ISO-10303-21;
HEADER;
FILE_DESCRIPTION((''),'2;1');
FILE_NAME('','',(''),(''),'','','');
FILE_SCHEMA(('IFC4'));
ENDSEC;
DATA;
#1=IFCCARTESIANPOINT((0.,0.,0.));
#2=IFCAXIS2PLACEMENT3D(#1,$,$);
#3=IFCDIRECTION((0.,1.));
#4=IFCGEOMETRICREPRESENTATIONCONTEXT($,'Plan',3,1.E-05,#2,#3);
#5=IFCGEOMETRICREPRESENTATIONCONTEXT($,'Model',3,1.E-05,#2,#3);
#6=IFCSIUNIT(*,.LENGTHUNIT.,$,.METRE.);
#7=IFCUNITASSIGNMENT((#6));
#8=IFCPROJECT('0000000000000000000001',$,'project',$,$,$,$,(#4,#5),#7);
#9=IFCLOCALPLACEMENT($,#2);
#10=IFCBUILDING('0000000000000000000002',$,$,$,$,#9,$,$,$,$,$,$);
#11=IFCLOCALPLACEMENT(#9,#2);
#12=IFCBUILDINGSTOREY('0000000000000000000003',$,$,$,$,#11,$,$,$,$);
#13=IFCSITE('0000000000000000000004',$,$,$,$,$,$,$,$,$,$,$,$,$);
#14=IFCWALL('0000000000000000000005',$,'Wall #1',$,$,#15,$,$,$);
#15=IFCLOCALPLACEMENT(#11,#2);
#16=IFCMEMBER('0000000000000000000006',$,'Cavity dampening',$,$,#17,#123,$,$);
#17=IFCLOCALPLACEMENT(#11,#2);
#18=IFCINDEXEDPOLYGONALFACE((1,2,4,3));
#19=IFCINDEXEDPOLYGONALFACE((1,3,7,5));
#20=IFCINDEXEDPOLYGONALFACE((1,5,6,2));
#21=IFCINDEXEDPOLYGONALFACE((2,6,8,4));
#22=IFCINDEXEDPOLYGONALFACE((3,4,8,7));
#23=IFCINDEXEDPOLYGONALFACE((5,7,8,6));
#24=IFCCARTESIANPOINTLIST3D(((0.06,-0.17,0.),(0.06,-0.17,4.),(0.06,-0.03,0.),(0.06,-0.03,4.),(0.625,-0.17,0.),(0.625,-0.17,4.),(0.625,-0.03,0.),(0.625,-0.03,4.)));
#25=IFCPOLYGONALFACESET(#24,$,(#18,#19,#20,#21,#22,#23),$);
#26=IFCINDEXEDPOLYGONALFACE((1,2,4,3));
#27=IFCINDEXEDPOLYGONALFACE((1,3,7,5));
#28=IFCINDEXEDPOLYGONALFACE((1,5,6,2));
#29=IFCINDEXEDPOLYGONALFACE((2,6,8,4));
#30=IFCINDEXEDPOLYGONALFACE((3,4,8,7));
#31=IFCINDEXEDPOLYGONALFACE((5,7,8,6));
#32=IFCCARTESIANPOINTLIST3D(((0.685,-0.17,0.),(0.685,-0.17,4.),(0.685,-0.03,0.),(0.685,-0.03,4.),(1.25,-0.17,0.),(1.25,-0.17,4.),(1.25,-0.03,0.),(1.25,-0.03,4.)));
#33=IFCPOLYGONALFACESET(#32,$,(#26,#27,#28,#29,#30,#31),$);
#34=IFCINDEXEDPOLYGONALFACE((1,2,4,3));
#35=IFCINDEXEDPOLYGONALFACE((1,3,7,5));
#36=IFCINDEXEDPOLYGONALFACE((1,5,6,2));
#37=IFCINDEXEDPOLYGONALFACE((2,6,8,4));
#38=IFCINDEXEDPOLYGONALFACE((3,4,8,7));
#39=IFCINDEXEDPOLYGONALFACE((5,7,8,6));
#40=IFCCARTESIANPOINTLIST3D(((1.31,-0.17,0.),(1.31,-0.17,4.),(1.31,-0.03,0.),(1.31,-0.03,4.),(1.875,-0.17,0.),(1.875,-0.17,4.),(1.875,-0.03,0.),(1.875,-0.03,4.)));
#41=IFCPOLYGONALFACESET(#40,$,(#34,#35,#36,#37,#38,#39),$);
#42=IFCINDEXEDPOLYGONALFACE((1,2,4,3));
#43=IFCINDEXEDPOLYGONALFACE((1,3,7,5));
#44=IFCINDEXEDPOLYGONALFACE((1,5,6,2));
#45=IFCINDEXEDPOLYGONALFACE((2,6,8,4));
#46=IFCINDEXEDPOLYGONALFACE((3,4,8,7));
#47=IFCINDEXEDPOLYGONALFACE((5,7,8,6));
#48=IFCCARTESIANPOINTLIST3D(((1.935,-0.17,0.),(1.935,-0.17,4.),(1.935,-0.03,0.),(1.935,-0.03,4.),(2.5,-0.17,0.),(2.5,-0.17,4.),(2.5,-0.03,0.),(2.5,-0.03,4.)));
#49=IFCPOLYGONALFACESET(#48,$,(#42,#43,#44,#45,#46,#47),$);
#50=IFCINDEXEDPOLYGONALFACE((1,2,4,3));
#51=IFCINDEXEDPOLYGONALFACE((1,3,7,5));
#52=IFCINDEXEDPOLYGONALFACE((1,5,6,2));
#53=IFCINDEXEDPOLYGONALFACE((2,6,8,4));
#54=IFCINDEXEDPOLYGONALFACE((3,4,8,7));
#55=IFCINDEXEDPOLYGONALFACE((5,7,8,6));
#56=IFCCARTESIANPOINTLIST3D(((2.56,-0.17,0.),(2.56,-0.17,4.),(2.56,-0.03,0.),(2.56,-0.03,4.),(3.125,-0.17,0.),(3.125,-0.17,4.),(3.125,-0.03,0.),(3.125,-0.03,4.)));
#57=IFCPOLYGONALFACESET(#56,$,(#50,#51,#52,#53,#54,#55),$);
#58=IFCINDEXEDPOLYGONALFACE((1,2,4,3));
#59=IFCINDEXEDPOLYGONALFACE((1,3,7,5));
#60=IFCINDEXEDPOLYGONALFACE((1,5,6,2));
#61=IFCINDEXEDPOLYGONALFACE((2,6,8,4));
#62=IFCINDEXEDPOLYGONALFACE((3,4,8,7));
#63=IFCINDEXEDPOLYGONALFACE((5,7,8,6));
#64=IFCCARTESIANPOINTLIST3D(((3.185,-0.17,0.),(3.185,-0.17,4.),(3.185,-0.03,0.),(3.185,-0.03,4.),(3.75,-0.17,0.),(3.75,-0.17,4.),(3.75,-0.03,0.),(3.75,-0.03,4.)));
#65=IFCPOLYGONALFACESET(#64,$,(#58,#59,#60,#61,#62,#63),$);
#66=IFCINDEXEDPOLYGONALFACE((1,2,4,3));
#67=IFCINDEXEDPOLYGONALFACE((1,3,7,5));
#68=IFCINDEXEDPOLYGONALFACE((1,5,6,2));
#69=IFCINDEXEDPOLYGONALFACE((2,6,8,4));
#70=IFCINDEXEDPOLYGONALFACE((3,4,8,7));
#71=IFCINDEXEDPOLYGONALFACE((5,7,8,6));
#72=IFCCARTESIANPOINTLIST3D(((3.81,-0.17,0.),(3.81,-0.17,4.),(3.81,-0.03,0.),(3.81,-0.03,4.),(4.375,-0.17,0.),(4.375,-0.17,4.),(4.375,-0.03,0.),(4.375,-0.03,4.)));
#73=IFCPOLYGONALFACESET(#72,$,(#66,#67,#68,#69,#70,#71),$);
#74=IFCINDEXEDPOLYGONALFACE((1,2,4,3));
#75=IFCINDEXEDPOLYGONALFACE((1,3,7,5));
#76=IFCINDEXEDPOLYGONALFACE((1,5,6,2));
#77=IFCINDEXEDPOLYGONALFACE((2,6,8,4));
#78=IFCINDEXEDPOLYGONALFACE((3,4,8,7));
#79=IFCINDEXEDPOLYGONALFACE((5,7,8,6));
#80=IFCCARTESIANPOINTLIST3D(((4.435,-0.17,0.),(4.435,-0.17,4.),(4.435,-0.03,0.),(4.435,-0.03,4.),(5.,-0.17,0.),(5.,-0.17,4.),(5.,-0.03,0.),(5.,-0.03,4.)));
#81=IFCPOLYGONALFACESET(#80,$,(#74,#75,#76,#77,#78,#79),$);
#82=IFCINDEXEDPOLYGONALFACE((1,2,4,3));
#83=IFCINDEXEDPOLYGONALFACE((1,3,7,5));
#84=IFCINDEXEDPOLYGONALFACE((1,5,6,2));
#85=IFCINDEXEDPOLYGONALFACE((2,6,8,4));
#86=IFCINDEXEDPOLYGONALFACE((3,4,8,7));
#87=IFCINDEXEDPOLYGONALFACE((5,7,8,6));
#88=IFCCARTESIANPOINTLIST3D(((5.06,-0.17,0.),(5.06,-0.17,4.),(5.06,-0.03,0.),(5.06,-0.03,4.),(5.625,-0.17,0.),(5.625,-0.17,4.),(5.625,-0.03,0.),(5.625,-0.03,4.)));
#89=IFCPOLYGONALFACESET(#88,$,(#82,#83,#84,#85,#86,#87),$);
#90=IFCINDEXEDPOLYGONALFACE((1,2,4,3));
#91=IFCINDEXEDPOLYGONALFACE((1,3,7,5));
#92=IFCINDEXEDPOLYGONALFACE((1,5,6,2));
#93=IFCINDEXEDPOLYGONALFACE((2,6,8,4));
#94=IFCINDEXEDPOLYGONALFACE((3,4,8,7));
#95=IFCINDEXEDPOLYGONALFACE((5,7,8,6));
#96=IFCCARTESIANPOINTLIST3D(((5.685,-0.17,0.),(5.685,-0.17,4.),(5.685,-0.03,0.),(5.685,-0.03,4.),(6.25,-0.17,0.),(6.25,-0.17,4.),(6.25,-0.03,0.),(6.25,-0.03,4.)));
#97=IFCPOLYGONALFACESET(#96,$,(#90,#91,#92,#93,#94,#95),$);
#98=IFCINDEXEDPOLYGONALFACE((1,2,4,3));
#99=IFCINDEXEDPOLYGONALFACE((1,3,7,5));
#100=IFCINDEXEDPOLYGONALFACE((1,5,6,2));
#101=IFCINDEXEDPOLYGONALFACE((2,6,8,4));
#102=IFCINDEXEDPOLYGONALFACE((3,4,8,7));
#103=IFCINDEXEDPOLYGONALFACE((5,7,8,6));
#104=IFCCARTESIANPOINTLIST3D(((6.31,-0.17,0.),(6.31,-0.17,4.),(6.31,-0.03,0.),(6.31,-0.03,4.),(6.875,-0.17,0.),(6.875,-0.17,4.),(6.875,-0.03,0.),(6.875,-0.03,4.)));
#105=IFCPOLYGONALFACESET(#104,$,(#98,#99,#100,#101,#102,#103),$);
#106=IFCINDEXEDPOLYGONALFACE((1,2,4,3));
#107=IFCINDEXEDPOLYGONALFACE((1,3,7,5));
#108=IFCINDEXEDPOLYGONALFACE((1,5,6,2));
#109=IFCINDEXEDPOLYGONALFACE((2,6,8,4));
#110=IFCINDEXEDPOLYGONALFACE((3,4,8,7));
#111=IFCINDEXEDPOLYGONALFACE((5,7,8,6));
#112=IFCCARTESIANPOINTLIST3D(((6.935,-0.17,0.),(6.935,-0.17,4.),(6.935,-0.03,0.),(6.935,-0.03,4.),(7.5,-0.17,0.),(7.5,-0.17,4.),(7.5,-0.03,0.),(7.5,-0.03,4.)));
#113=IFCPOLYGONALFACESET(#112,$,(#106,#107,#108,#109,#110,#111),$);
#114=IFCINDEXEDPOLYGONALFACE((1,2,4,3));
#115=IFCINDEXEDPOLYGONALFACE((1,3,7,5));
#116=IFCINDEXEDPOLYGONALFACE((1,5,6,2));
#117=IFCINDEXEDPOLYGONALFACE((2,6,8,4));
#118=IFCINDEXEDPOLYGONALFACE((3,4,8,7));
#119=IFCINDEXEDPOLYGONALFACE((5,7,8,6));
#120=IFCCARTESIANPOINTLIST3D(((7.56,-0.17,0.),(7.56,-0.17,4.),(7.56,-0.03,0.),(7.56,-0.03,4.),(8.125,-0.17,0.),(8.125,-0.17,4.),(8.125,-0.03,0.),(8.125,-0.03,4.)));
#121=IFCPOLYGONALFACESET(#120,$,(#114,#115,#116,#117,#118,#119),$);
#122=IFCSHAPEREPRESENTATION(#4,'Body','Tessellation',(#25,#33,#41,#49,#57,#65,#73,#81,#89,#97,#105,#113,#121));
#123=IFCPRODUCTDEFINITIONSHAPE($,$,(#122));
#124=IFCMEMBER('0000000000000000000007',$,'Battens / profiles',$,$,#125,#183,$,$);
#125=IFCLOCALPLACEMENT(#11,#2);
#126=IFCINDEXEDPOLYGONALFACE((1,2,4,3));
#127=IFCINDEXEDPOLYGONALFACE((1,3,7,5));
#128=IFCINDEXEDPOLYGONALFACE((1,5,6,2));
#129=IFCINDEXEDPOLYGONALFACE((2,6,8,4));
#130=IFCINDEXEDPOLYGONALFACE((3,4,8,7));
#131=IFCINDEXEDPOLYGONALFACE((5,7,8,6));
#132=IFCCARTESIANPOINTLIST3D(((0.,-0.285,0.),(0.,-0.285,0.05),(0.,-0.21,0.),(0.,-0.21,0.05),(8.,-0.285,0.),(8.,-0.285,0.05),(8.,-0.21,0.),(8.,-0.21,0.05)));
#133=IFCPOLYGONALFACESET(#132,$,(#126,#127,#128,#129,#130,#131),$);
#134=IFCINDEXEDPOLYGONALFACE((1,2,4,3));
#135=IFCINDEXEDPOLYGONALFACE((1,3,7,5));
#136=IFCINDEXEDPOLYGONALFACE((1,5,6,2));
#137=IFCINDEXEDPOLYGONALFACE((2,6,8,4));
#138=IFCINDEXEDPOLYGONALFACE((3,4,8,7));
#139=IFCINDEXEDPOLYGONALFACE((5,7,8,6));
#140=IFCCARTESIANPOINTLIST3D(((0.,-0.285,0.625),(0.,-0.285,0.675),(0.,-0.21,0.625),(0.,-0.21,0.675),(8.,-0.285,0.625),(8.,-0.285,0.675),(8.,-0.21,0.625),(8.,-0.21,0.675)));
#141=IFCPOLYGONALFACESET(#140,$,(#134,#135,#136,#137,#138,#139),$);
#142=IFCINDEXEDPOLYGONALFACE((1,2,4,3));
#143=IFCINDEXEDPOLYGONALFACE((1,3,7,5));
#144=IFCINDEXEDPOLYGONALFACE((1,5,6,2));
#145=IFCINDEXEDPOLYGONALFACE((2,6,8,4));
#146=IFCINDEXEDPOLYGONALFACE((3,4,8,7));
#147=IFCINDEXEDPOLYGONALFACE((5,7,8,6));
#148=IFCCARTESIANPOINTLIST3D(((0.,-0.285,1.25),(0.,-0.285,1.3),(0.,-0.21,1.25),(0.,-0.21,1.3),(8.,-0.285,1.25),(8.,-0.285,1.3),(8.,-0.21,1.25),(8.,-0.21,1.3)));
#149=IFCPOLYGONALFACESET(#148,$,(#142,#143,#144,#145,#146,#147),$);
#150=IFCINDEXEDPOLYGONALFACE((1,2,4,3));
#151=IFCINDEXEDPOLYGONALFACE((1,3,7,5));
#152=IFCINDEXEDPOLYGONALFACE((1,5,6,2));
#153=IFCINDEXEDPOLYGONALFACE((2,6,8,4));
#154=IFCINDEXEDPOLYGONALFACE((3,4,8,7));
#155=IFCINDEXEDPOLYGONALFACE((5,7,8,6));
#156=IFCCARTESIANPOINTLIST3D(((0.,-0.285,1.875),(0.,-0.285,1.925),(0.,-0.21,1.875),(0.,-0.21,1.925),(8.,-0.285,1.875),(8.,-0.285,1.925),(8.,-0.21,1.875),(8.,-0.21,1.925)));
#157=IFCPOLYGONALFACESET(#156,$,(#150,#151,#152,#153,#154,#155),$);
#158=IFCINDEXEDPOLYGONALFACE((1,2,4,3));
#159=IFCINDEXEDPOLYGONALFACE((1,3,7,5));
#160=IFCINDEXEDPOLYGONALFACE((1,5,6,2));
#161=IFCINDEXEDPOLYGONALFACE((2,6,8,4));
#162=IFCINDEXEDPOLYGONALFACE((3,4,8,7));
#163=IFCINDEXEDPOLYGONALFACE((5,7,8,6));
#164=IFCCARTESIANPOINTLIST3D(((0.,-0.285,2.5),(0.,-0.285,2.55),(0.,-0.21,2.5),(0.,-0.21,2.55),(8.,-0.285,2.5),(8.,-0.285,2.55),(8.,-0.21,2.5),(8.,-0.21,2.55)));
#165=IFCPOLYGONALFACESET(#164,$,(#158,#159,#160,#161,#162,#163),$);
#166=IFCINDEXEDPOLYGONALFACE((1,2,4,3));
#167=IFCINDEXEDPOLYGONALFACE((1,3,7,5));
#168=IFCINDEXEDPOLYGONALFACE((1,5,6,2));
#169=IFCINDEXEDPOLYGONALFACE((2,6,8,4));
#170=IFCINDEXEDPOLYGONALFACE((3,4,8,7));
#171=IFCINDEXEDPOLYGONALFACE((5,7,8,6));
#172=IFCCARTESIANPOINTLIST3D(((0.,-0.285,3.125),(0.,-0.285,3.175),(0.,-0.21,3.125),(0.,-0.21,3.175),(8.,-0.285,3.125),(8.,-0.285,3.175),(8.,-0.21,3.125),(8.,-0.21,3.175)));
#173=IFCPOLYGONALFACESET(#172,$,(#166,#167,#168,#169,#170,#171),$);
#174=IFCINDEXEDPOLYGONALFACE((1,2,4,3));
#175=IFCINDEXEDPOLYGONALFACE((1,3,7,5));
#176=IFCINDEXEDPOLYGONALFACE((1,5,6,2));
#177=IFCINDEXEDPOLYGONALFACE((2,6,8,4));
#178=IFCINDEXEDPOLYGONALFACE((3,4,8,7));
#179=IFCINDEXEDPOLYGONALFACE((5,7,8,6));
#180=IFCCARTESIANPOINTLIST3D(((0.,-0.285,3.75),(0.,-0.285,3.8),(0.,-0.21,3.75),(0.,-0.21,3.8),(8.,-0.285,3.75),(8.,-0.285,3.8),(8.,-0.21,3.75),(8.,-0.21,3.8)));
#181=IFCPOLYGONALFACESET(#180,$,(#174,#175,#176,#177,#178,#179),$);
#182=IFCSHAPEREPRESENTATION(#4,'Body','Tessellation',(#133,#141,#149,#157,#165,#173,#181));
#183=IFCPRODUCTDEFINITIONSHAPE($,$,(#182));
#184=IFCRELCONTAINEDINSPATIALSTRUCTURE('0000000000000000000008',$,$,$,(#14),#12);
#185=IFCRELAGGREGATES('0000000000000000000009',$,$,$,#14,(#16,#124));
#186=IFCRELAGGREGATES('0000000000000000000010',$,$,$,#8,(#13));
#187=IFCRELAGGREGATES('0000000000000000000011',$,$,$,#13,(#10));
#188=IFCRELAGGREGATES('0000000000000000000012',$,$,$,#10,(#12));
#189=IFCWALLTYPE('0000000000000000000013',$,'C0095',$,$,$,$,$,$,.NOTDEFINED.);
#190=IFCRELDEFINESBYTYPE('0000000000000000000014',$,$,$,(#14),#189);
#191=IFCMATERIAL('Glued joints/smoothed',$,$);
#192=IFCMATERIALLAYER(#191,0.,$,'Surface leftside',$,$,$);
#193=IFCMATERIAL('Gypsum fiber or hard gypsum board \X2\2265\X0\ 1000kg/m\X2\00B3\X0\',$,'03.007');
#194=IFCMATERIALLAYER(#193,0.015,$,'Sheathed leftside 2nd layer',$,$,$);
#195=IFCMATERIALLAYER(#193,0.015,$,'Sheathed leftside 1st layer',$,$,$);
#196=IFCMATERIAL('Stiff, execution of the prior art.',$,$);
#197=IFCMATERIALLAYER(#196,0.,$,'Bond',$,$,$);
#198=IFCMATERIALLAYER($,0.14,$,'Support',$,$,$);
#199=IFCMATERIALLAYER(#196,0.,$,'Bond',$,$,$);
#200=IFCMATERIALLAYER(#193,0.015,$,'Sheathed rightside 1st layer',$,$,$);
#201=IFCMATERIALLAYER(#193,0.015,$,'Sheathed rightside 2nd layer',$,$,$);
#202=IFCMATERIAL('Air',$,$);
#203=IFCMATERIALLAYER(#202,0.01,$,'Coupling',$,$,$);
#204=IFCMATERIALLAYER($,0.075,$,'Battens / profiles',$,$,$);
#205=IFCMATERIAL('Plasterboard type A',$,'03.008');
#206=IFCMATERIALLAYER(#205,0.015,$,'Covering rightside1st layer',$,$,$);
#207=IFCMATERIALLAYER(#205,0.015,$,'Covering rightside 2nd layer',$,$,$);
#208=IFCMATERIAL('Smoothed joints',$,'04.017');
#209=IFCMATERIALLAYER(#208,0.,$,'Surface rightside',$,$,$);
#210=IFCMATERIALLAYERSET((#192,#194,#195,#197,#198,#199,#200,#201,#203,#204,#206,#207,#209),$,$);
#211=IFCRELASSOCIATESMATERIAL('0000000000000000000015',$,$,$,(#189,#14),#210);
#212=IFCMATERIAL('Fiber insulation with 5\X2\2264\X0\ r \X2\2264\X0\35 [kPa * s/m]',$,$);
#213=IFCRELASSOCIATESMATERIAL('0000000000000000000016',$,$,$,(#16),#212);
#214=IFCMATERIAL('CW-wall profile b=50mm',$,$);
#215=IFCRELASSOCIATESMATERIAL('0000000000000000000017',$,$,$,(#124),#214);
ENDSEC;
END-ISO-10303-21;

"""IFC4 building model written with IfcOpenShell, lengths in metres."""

from ifc_helpers import new_model, si_unit, direction, frame, frame_2d, origin, place, context, project, spatial, rectangle, extrude, material, layer, layer_set, type_object, element, aggregate, save


model = new_model("IFC4")

# Units and contexts
plan_context = context("Plan", 3, precision=1e-05, world=origin(), true_north=direction((0.0, 1.0)))
model_context = context("Model", 3, precision=1e-05, world=origin(), true_north=direction((0.0, 1.0)))
ifc_project = project(units=[si_unit("LENGTHUNIT", "METRE")], contexts=[plan_context, model_context])

# Site, building, storey
site = spatial("IfcSite", under=ifc_project)
building_placement = place(None, origin())
building = spatial("IfcBuilding", under=site, at=building_placement)
storey_placement = place(building_placement, origin())
storey = spatial("IfcBuildingStorey", under=building, at=storey_placement)

# Wall, members
ifc_material_1 = material(Name="Glued joints/smoothed")
ifc_layer_1 = layer(ifc_material_1, 0.0, Name="Surface leftside")
ifc_material_2 = material(Name="Gypsum fiber or hard gypsum board ≥ 1000kg/m³", Category="03.007")
ifc_layer_2 = layer(ifc_material_2, 0.015, Name="Sheathed leftside 2nd layer")
ifc_layer_3 = layer(ifc_material_2, 0.015, Name="Sheathed leftside 1st layer")
ifc_material_3 = material(Name="Stiff, execution of the prior art.")
ifc_layer_4 = layer(ifc_material_3, 0.0, Name="Bond")
ifc_layer_5 = layer(None, 0.14, Name="Support")
ifc_layer_6 = layer(ifc_material_3, 0.0, Name="Bond")
ifc_layer_7 = layer(ifc_material_2, 0.015, Name="Sheathed rightside 1st layer")
ifc_layer_8 = layer(ifc_material_2, 0.015, Name="Sheathed rightside 2nd layer")
ifc_material_4 = material(Name="Air")
ifc_layer_9 = layer(ifc_material_4, 0.01, Name="Coupling")
ifc_layer_10 = layer(None, 0.075, Name="Battens / profiles")
ifc_material_5 = material(Name="Plasterboard type A", Category="03.008")
ifc_layer_11 = layer(ifc_material_5, 0.015, Name="Covering rightside1st layer")
ifc_layer_12 = layer(ifc_material_5, 0.015, Name="Covering rightside 2nd layer")
ifc_material_6 = material(Name="Smoothed joints", Category="04.017")
ifc_layer_13 = layer(ifc_material_6, 0.0, Name="Surface rightside")
ifc_layer_set = layer_set([ifc_layer_1, ifc_layer_2, ifc_layer_3, ifc_layer_4, ifc_layer_5, ifc_layer_6, ifc_layer_7, ifc_layer_8, ifc_layer_9, ifc_layer_10, ifc_layer_11, ifc_layer_12, ifc_layer_13])
wall_type = type_object("IfcWallType", Name="C0095", PredefinedType="NOTDEFINED", material=ifc_layer_set)
wall_placement = place(None, frame((0.0, 0.0, 0.0), z_axis=(0.0, -1.0, 0.0), x_axis=(1.0, 0.0, 0.0)))
wall = element("IfcWall", 1, at=wall_placement, inside=storey, type_object=wall_type, material=ifc_layer_set, Name="Wall #1")
ifc_material_7 = material(Name="Fiber insulation with 5≤ r ≤35 [kPa * s/m]")
member_1_placement = place(wall_placement, origin())
member_1 = element("IfcMember", 2, at=member_1_placement, material=ifc_material_7, Name="Cavity dampening", context=plan_context, shape_type="SweptSolid", body=[
    extrude(rectangle(XDim=0.565, YDim=0.14, at=frame_2d((0.2825, 0.07), x_axis=(1.0, 0.0))), frame((0.06, 4.0, 0.03), z_axis=(0.0, -1.0, 0.0), x_axis=(1.0, 0.0, 0.0)), (0.0, 0.0, 1.0), 4.0),
    extrude(rectangle(XDim=0.565, YDim=0.14, at=frame_2d((0.2825, 0.07), x_axis=(1.0, 0.0))), frame((0.685, 4.0, 0.03), z_axis=(0.0, -1.0, 0.0), x_axis=(1.0, 0.0, 0.0)), (0.0, 0.0, 1.0), 4.0),
    extrude(rectangle(XDim=0.565, YDim=0.14, at=frame_2d((0.2825, 0.07), x_axis=(1.0, 0.0))), frame((1.31, 4.0, 0.03), z_axis=(0.0, -1.0, 0.0), x_axis=(1.0, 0.0, 0.0)), (0.0, 0.0, 1.0), 4.0),
    extrude(rectangle(XDim=0.565, YDim=0.14, at=frame_2d((0.2825, 0.07), x_axis=(1.0, 0.0))), frame((1.935, 4.0, 0.03), z_axis=(0.0, -1.0, 0.0), x_axis=(1.0, 0.0, 0.0)), (0.0, 0.0, 1.0), 4.0),
    extrude(rectangle(XDim=0.565, YDim=0.14, at=frame_2d((0.2825, 0.07), x_axis=(1.0, 0.0))), frame((2.56, 4.0, 0.03), z_axis=(0.0, -1.0, 0.0), x_axis=(1.0, 0.0, 0.0)), (0.0, 0.0, 1.0), 4.0),
    extrude(rectangle(XDim=0.565, YDim=0.14, at=frame_2d((0.2825, 0.07), x_axis=(1.0, 0.0))), frame((3.185, 4.0, 0.03), z_axis=(0.0, -1.0, 0.0), x_axis=(1.0, 0.0, 0.0)), (0.0, 0.0, 1.0), 4.0),
    extrude(rectangle(XDim=0.565, YDim=0.14, at=frame_2d((0.2825, 0.07), x_axis=(1.0, 0.0))), frame((3.81, 4.0, 0.03), z_axis=(0.0, -1.0, 0.0), x_axis=(1.0, 0.0, 0.0)), (0.0, 0.0, 1.0), 4.0),
    extrude(rectangle(XDim=0.565, YDim=0.14, at=frame_2d((0.2825, 0.07), x_axis=(1.0, 0.0))), frame((4.435, 4.0, 0.03), z_axis=(0.0, -1.0, 0.0), x_axis=(1.0, 0.0, 0.0)), (0.0, 0.0, 1.0), 4.0),
    extrude(rectangle(XDim=0.565, YDim=0.14, at=frame_2d((0.2825, 0.07), x_axis=(1.0, 0.0))), frame((5.06, 4.0, 0.03), z_axis=(0.0, -1.0, 0.0), x_axis=(1.0, 0.0, 0.0)), (0.0, 0.0, 1.0), 4.0),
    extrude(rectangle(XDim=0.565, YDim=0.14, at=frame_2d((0.2825, 0.07), x_axis=(1.0, 0.0))), frame((5.685, 4.0, 0.03), z_axis=(0.0, -1.0, 0.0), x_axis=(1.0, 0.0, 0.0)), (0.0, 0.0, 1.0), 4.0),
    extrude(rectangle(XDim=0.565, YDim=0.14, at=frame_2d((0.2825, 0.07), x_axis=(1.0, 0.0))), frame((6.31, 4.0, 0.03), z_axis=(0.0, -1.0, 0.0), x_axis=(1.0, 0.0, 0.0)), (0.0, 0.0, 1.0), 4.0),
    extrude(rectangle(XDim=0.565, YDim=0.14, at=frame_2d((0.2825, 0.07), x_axis=(1.0, 0.0))), frame((6.935, 4.0, 0.03), z_axis=(0.0, -1.0, 0.0), x_axis=(1.0, 0.0, 0.0)), (0.0, 0.0, 1.0), 4.0),
    extrude(rectangle(XDim=0.565, YDim=0.14, at=frame_2d((0.2825, 0.07), x_axis=(1.0, 0.0))), frame((7.56, 4.0, 0.03), z_axis=(0.0, -1.0, 0.0), x_axis=(1.0, 0.0, 0.0)), (0.0, 0.0, 1.0), 4.0),
])
ifc_material_8 = material(Name="CW-wall profile b=50mm")
member_2_placement = place(wall_placement, origin())
member_2 = element("IfcMember", 3, at=member_2_placement, material=ifc_material_8, Name="Battens / profiles", context=plan_context, shape_type="SweptSolid", body=[
    extrude(rectangle(XDim=0.05, YDim=0.075, at=frame_2d((0.025, 0.0375), x_axis=(1.0, 0.0))), frame((0.0, 0.0, 0.21), z_axis=(1.0, 0.0, 0.0), x_axis=(0.0, 1.0, 0.0)), (0.0, 0.0, 1.0), 8.0),
    extrude(rectangle(XDim=0.05, YDim=0.075, at=frame_2d((0.025, 0.0375), x_axis=(1.0, 0.0))), frame((0.0, 0.625, 0.21), z_axis=(1.0, 0.0, 0.0), x_axis=(0.0, 1.0, 0.0)), (0.0, 0.0, 1.0), 8.0),
    extrude(rectangle(XDim=0.05, YDim=0.075, at=frame_2d((0.025, 0.0375), x_axis=(1.0, 0.0))), frame((0.0, 1.25, 0.21), z_axis=(1.0, 0.0, 0.0), x_axis=(0.0, 1.0, 0.0)), (0.0, 0.0, 1.0), 8.0),
    extrude(rectangle(XDim=0.05, YDim=0.075, at=frame_2d((0.025, 0.0375), x_axis=(1.0, 0.0))), frame((0.0, 1.875, 0.21), z_axis=(1.0, 0.0, 0.0), x_axis=(0.0, 1.0, 0.0)), (0.0, 0.0, 1.0), 8.0),
    extrude(rectangle(XDim=0.05, YDim=0.075, at=frame_2d((0.025, 0.0375), x_axis=(1.0, 0.0))), frame((0.0, 2.5, 0.21), z_axis=(1.0, 0.0, 0.0), x_axis=(0.0, 1.0, 0.0)), (0.0, 0.0, 1.0), 8.0),
    extrude(rectangle(XDim=0.05, YDim=0.075, at=frame_2d((0.025, 0.0375), x_axis=(1.0, 0.0))), frame((0.0, 3.125, 0.21), z_axis=(1.0, 0.0, 0.0), x_axis=(0.0, 1.0, 0.0)), (0.0, 0.0, 1.0), 8.0),
    extrude(rectangle(XDim=0.05, YDim=0.075, at=frame_2d((0.025, 0.0375), x_axis=(1.0, 0.0))), frame((0.0, 3.75, 0.21), z_axis=(1.0, 0.0, 0.0), x_axis=(0.0, 1.0, 0.0)), (0.0, 0.0, 1.0), 8.0),
])
aggregate(wall, [member_1, member_2])

save(model, "model.ifc")
